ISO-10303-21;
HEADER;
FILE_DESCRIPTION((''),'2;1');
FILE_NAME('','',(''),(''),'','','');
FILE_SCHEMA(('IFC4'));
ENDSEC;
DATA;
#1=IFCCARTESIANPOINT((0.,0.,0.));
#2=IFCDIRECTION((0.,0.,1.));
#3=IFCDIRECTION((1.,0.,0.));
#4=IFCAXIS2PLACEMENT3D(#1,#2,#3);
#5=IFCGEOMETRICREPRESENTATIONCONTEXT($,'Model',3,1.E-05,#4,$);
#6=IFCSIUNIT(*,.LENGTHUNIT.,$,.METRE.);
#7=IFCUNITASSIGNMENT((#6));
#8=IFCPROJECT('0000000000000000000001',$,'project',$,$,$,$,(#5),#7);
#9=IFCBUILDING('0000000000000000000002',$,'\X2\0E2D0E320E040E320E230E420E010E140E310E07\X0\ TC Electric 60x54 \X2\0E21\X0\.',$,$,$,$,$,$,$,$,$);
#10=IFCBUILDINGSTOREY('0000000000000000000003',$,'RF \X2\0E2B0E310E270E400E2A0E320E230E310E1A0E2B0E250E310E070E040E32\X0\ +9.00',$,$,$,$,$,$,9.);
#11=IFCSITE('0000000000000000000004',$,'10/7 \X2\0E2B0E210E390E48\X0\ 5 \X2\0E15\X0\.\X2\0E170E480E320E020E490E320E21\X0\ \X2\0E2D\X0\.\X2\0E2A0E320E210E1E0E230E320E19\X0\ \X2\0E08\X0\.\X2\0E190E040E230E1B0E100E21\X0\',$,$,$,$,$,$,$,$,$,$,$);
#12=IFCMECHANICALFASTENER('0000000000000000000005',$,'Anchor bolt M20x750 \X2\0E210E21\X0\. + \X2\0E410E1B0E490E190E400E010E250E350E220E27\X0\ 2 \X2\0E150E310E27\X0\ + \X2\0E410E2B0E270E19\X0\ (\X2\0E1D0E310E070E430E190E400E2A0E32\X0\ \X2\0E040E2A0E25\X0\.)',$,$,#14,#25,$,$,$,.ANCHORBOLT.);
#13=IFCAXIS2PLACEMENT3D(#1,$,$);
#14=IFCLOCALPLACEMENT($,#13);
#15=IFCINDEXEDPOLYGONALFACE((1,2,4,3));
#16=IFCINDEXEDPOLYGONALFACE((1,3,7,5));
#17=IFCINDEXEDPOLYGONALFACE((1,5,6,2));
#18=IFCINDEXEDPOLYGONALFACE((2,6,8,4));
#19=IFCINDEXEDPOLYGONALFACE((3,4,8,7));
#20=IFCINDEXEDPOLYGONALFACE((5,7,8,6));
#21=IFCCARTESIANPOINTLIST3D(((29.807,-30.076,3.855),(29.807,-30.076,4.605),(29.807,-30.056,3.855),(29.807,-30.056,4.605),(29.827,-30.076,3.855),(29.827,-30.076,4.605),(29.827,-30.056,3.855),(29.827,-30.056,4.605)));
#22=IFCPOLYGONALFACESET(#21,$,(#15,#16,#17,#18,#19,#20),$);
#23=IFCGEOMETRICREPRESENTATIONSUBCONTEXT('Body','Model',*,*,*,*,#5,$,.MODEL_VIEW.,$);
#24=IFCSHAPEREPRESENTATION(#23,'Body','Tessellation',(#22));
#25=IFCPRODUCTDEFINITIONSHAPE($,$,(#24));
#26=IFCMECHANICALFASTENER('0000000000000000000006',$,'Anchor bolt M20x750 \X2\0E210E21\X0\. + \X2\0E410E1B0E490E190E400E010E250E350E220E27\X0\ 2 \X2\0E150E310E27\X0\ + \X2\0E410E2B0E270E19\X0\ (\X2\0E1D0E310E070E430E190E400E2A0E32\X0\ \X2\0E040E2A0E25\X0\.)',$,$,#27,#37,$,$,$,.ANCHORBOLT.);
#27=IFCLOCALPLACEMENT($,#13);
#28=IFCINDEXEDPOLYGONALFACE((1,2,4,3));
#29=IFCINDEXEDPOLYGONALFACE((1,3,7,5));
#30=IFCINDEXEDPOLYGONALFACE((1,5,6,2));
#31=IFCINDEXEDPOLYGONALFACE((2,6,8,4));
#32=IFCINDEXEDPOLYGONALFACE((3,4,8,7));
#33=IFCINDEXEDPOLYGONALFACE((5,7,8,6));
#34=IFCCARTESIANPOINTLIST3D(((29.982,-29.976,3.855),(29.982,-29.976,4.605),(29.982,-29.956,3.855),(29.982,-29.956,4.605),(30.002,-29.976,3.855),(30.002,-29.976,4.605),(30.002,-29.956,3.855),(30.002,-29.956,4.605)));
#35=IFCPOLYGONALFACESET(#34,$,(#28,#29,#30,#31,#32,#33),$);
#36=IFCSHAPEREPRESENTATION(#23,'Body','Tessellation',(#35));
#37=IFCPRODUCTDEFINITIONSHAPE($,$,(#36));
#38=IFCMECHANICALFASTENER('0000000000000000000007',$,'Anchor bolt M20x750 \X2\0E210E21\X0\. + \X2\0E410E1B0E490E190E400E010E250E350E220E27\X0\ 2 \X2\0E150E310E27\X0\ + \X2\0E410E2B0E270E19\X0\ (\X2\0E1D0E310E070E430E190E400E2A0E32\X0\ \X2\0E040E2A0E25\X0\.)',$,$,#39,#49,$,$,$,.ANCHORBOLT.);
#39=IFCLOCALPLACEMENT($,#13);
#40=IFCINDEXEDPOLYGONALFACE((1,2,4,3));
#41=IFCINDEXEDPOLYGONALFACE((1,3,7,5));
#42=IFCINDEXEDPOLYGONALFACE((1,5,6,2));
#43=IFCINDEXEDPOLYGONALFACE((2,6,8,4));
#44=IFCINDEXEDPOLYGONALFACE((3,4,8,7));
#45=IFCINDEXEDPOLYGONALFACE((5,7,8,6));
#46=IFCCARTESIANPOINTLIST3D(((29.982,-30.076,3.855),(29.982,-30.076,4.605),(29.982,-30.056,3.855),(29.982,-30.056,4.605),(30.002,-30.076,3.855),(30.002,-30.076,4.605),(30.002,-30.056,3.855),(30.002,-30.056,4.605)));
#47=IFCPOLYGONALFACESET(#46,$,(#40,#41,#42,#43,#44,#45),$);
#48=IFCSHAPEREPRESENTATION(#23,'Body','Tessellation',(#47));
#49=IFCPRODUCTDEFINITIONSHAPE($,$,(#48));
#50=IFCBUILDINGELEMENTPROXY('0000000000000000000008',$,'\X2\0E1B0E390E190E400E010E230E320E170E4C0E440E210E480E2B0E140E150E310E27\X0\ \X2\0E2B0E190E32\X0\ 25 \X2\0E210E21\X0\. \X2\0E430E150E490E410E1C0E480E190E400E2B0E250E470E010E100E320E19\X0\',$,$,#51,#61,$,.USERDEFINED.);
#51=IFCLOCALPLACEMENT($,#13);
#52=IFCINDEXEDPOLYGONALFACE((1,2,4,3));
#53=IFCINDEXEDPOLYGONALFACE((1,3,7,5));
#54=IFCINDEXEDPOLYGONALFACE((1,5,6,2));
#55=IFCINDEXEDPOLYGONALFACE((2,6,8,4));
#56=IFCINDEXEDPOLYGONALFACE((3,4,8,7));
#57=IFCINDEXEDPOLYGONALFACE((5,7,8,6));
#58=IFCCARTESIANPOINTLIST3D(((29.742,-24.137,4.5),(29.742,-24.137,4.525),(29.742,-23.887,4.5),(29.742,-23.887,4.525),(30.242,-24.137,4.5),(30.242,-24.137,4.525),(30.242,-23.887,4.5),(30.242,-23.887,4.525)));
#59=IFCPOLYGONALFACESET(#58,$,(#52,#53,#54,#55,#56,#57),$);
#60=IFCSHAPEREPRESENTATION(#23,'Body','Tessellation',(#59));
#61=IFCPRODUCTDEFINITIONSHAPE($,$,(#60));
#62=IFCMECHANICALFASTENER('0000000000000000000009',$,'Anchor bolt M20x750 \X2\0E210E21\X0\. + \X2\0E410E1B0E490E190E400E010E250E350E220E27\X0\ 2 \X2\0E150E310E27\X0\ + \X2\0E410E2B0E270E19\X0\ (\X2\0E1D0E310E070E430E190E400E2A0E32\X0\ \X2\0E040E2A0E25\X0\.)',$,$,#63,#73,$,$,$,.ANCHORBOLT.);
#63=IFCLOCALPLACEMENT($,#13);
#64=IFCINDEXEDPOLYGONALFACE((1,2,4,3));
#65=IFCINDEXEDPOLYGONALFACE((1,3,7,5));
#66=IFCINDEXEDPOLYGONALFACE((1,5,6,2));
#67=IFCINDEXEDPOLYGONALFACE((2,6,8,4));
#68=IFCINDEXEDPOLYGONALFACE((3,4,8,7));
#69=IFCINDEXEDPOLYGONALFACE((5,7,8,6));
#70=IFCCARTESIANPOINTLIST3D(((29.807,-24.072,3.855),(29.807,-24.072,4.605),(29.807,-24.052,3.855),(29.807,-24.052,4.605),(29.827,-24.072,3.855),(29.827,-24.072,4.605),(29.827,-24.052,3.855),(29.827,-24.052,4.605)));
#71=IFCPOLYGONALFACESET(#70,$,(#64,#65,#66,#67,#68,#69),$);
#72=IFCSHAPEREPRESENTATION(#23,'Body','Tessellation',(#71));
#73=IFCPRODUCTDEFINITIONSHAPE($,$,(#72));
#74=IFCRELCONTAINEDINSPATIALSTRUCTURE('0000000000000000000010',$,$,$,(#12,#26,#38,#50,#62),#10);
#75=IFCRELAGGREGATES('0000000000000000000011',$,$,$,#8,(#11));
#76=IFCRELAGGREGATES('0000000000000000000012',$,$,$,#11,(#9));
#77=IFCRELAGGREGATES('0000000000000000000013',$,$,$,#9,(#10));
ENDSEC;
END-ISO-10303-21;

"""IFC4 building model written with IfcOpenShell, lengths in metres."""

from ifc_helpers import new_model, si_unit, frame, origin, origin_with_axes, origin_2d, place, context, subcontext, project, spatial, rectangle, extrude, element, save


model = new_model("IFC4")

# Units and contexts
model_context = context("Model", 3, precision=1e-05, world=origin_with_axes())
body_context = subcontext(model_context, "Body", "Model", "MODEL_VIEW")
ifc_project = project(units=[si_unit("LENGTHUNIT", "METRE")], contexts=[model_context])

# Site, building, storey
site = spatial("IfcSite", under=ifc_project, Name="10/7 หมู่ 5 ต.ท่าข้าม อ.สามพราน จ.นครปฐม")
building = spatial("IfcBuilding", under=site, Name="อาคารโกดัง TC Electric 60x54 ม.")
storey = spatial("IfcBuildingStorey", under=building, Name="RF หัวเสารับหลังคา +9.00", Elevation=9.0)

# Mechanical fasteners
for number, where, z_axis, x_axis, name in (
    (1, (29.817, -30.066, 3.855), (0.0, 0.0, 1.0), (1.0, 0.0, 0.0), "Anchor bolt M20x750 มม. + แป้นเกลียว 2 ตัว + แหวน (ฝังในเสา คสล.)"),
    (2, (29.992, -29.966, 3.855), (0.0, 0.0, 1.0), (1.0, 0.0, 0.0), "Anchor bolt M20x750 มม. + แป้นเกลียว 2 ตัว + แหวน (ฝังในเสา คสล.)"),
    (3, (29.992, -30.066, 3.855), (0.0, 0.0, 1.0), (1.0, 0.0, 0.0), "Anchor bolt M20x750 มม. + แป้นเกลียว 2 ตัว + แหวน (ฝังในเสา คสล.)"),
):
    element("IfcMechanicalFastener", number, at=place(None, frame(where, z_axis=z_axis, x_axis=x_axis)), inside=storey, Name=name, PredefinedType="ANCHORBOLT", context=body_context, shape_type="SweptSolid", body=[
        extrude(rectangle(XDim=0.02, YDim=0.02, at=origin_2d()), origin(), (0.0, 0.0, 1.0), 0.75),
    ])

# Building element proxy
proxy_1_placement = place(None, frame((29.992, -24.012, 4.5), z_axis=(0.0, 0.0, 1.0), x_axis=(1.0, 0.0, 0.0)))
element("IfcBuildingElementProxy", 4, at=proxy_1_placement, inside=storey, Name="ปูนเกราท์ไม่หดตัว หนา 25 มม. ใต้แผ่นเหล็กฐาน", PredefinedType="USERDEFINED", context=body_context, shape_type="SweptSolid", body=[
    extrude(rectangle(XDim=0.5, YDim=0.25, at=origin_2d()), origin(), (0.0, 0.0, 1.0), 0.025),
])

# Mechanical fastener
mechanical_fastener_placement = place(None, frame((29.817, -24.062, 3.855), z_axis=(0.0, 0.0, 1.0), x_axis=(1.0, 0.0, 0.0)))
element("IfcMechanicalFastener", 5, at=mechanical_fastener_placement, inside=storey, Name="Anchor bolt M20x750 มม. + แป้นเกลียว 2 ตัว + แหวน (ฝังในเสา คสล.)", PredefinedType="ANCHORBOLT", context=body_context, shape_type="SweptSolid", body=[
    extrude(rectangle(XDim=0.02, YDim=0.02, at=origin_2d()), origin(), (0.0, 0.0, 1.0), 0.75),
])

save(model, "model.ifc")
